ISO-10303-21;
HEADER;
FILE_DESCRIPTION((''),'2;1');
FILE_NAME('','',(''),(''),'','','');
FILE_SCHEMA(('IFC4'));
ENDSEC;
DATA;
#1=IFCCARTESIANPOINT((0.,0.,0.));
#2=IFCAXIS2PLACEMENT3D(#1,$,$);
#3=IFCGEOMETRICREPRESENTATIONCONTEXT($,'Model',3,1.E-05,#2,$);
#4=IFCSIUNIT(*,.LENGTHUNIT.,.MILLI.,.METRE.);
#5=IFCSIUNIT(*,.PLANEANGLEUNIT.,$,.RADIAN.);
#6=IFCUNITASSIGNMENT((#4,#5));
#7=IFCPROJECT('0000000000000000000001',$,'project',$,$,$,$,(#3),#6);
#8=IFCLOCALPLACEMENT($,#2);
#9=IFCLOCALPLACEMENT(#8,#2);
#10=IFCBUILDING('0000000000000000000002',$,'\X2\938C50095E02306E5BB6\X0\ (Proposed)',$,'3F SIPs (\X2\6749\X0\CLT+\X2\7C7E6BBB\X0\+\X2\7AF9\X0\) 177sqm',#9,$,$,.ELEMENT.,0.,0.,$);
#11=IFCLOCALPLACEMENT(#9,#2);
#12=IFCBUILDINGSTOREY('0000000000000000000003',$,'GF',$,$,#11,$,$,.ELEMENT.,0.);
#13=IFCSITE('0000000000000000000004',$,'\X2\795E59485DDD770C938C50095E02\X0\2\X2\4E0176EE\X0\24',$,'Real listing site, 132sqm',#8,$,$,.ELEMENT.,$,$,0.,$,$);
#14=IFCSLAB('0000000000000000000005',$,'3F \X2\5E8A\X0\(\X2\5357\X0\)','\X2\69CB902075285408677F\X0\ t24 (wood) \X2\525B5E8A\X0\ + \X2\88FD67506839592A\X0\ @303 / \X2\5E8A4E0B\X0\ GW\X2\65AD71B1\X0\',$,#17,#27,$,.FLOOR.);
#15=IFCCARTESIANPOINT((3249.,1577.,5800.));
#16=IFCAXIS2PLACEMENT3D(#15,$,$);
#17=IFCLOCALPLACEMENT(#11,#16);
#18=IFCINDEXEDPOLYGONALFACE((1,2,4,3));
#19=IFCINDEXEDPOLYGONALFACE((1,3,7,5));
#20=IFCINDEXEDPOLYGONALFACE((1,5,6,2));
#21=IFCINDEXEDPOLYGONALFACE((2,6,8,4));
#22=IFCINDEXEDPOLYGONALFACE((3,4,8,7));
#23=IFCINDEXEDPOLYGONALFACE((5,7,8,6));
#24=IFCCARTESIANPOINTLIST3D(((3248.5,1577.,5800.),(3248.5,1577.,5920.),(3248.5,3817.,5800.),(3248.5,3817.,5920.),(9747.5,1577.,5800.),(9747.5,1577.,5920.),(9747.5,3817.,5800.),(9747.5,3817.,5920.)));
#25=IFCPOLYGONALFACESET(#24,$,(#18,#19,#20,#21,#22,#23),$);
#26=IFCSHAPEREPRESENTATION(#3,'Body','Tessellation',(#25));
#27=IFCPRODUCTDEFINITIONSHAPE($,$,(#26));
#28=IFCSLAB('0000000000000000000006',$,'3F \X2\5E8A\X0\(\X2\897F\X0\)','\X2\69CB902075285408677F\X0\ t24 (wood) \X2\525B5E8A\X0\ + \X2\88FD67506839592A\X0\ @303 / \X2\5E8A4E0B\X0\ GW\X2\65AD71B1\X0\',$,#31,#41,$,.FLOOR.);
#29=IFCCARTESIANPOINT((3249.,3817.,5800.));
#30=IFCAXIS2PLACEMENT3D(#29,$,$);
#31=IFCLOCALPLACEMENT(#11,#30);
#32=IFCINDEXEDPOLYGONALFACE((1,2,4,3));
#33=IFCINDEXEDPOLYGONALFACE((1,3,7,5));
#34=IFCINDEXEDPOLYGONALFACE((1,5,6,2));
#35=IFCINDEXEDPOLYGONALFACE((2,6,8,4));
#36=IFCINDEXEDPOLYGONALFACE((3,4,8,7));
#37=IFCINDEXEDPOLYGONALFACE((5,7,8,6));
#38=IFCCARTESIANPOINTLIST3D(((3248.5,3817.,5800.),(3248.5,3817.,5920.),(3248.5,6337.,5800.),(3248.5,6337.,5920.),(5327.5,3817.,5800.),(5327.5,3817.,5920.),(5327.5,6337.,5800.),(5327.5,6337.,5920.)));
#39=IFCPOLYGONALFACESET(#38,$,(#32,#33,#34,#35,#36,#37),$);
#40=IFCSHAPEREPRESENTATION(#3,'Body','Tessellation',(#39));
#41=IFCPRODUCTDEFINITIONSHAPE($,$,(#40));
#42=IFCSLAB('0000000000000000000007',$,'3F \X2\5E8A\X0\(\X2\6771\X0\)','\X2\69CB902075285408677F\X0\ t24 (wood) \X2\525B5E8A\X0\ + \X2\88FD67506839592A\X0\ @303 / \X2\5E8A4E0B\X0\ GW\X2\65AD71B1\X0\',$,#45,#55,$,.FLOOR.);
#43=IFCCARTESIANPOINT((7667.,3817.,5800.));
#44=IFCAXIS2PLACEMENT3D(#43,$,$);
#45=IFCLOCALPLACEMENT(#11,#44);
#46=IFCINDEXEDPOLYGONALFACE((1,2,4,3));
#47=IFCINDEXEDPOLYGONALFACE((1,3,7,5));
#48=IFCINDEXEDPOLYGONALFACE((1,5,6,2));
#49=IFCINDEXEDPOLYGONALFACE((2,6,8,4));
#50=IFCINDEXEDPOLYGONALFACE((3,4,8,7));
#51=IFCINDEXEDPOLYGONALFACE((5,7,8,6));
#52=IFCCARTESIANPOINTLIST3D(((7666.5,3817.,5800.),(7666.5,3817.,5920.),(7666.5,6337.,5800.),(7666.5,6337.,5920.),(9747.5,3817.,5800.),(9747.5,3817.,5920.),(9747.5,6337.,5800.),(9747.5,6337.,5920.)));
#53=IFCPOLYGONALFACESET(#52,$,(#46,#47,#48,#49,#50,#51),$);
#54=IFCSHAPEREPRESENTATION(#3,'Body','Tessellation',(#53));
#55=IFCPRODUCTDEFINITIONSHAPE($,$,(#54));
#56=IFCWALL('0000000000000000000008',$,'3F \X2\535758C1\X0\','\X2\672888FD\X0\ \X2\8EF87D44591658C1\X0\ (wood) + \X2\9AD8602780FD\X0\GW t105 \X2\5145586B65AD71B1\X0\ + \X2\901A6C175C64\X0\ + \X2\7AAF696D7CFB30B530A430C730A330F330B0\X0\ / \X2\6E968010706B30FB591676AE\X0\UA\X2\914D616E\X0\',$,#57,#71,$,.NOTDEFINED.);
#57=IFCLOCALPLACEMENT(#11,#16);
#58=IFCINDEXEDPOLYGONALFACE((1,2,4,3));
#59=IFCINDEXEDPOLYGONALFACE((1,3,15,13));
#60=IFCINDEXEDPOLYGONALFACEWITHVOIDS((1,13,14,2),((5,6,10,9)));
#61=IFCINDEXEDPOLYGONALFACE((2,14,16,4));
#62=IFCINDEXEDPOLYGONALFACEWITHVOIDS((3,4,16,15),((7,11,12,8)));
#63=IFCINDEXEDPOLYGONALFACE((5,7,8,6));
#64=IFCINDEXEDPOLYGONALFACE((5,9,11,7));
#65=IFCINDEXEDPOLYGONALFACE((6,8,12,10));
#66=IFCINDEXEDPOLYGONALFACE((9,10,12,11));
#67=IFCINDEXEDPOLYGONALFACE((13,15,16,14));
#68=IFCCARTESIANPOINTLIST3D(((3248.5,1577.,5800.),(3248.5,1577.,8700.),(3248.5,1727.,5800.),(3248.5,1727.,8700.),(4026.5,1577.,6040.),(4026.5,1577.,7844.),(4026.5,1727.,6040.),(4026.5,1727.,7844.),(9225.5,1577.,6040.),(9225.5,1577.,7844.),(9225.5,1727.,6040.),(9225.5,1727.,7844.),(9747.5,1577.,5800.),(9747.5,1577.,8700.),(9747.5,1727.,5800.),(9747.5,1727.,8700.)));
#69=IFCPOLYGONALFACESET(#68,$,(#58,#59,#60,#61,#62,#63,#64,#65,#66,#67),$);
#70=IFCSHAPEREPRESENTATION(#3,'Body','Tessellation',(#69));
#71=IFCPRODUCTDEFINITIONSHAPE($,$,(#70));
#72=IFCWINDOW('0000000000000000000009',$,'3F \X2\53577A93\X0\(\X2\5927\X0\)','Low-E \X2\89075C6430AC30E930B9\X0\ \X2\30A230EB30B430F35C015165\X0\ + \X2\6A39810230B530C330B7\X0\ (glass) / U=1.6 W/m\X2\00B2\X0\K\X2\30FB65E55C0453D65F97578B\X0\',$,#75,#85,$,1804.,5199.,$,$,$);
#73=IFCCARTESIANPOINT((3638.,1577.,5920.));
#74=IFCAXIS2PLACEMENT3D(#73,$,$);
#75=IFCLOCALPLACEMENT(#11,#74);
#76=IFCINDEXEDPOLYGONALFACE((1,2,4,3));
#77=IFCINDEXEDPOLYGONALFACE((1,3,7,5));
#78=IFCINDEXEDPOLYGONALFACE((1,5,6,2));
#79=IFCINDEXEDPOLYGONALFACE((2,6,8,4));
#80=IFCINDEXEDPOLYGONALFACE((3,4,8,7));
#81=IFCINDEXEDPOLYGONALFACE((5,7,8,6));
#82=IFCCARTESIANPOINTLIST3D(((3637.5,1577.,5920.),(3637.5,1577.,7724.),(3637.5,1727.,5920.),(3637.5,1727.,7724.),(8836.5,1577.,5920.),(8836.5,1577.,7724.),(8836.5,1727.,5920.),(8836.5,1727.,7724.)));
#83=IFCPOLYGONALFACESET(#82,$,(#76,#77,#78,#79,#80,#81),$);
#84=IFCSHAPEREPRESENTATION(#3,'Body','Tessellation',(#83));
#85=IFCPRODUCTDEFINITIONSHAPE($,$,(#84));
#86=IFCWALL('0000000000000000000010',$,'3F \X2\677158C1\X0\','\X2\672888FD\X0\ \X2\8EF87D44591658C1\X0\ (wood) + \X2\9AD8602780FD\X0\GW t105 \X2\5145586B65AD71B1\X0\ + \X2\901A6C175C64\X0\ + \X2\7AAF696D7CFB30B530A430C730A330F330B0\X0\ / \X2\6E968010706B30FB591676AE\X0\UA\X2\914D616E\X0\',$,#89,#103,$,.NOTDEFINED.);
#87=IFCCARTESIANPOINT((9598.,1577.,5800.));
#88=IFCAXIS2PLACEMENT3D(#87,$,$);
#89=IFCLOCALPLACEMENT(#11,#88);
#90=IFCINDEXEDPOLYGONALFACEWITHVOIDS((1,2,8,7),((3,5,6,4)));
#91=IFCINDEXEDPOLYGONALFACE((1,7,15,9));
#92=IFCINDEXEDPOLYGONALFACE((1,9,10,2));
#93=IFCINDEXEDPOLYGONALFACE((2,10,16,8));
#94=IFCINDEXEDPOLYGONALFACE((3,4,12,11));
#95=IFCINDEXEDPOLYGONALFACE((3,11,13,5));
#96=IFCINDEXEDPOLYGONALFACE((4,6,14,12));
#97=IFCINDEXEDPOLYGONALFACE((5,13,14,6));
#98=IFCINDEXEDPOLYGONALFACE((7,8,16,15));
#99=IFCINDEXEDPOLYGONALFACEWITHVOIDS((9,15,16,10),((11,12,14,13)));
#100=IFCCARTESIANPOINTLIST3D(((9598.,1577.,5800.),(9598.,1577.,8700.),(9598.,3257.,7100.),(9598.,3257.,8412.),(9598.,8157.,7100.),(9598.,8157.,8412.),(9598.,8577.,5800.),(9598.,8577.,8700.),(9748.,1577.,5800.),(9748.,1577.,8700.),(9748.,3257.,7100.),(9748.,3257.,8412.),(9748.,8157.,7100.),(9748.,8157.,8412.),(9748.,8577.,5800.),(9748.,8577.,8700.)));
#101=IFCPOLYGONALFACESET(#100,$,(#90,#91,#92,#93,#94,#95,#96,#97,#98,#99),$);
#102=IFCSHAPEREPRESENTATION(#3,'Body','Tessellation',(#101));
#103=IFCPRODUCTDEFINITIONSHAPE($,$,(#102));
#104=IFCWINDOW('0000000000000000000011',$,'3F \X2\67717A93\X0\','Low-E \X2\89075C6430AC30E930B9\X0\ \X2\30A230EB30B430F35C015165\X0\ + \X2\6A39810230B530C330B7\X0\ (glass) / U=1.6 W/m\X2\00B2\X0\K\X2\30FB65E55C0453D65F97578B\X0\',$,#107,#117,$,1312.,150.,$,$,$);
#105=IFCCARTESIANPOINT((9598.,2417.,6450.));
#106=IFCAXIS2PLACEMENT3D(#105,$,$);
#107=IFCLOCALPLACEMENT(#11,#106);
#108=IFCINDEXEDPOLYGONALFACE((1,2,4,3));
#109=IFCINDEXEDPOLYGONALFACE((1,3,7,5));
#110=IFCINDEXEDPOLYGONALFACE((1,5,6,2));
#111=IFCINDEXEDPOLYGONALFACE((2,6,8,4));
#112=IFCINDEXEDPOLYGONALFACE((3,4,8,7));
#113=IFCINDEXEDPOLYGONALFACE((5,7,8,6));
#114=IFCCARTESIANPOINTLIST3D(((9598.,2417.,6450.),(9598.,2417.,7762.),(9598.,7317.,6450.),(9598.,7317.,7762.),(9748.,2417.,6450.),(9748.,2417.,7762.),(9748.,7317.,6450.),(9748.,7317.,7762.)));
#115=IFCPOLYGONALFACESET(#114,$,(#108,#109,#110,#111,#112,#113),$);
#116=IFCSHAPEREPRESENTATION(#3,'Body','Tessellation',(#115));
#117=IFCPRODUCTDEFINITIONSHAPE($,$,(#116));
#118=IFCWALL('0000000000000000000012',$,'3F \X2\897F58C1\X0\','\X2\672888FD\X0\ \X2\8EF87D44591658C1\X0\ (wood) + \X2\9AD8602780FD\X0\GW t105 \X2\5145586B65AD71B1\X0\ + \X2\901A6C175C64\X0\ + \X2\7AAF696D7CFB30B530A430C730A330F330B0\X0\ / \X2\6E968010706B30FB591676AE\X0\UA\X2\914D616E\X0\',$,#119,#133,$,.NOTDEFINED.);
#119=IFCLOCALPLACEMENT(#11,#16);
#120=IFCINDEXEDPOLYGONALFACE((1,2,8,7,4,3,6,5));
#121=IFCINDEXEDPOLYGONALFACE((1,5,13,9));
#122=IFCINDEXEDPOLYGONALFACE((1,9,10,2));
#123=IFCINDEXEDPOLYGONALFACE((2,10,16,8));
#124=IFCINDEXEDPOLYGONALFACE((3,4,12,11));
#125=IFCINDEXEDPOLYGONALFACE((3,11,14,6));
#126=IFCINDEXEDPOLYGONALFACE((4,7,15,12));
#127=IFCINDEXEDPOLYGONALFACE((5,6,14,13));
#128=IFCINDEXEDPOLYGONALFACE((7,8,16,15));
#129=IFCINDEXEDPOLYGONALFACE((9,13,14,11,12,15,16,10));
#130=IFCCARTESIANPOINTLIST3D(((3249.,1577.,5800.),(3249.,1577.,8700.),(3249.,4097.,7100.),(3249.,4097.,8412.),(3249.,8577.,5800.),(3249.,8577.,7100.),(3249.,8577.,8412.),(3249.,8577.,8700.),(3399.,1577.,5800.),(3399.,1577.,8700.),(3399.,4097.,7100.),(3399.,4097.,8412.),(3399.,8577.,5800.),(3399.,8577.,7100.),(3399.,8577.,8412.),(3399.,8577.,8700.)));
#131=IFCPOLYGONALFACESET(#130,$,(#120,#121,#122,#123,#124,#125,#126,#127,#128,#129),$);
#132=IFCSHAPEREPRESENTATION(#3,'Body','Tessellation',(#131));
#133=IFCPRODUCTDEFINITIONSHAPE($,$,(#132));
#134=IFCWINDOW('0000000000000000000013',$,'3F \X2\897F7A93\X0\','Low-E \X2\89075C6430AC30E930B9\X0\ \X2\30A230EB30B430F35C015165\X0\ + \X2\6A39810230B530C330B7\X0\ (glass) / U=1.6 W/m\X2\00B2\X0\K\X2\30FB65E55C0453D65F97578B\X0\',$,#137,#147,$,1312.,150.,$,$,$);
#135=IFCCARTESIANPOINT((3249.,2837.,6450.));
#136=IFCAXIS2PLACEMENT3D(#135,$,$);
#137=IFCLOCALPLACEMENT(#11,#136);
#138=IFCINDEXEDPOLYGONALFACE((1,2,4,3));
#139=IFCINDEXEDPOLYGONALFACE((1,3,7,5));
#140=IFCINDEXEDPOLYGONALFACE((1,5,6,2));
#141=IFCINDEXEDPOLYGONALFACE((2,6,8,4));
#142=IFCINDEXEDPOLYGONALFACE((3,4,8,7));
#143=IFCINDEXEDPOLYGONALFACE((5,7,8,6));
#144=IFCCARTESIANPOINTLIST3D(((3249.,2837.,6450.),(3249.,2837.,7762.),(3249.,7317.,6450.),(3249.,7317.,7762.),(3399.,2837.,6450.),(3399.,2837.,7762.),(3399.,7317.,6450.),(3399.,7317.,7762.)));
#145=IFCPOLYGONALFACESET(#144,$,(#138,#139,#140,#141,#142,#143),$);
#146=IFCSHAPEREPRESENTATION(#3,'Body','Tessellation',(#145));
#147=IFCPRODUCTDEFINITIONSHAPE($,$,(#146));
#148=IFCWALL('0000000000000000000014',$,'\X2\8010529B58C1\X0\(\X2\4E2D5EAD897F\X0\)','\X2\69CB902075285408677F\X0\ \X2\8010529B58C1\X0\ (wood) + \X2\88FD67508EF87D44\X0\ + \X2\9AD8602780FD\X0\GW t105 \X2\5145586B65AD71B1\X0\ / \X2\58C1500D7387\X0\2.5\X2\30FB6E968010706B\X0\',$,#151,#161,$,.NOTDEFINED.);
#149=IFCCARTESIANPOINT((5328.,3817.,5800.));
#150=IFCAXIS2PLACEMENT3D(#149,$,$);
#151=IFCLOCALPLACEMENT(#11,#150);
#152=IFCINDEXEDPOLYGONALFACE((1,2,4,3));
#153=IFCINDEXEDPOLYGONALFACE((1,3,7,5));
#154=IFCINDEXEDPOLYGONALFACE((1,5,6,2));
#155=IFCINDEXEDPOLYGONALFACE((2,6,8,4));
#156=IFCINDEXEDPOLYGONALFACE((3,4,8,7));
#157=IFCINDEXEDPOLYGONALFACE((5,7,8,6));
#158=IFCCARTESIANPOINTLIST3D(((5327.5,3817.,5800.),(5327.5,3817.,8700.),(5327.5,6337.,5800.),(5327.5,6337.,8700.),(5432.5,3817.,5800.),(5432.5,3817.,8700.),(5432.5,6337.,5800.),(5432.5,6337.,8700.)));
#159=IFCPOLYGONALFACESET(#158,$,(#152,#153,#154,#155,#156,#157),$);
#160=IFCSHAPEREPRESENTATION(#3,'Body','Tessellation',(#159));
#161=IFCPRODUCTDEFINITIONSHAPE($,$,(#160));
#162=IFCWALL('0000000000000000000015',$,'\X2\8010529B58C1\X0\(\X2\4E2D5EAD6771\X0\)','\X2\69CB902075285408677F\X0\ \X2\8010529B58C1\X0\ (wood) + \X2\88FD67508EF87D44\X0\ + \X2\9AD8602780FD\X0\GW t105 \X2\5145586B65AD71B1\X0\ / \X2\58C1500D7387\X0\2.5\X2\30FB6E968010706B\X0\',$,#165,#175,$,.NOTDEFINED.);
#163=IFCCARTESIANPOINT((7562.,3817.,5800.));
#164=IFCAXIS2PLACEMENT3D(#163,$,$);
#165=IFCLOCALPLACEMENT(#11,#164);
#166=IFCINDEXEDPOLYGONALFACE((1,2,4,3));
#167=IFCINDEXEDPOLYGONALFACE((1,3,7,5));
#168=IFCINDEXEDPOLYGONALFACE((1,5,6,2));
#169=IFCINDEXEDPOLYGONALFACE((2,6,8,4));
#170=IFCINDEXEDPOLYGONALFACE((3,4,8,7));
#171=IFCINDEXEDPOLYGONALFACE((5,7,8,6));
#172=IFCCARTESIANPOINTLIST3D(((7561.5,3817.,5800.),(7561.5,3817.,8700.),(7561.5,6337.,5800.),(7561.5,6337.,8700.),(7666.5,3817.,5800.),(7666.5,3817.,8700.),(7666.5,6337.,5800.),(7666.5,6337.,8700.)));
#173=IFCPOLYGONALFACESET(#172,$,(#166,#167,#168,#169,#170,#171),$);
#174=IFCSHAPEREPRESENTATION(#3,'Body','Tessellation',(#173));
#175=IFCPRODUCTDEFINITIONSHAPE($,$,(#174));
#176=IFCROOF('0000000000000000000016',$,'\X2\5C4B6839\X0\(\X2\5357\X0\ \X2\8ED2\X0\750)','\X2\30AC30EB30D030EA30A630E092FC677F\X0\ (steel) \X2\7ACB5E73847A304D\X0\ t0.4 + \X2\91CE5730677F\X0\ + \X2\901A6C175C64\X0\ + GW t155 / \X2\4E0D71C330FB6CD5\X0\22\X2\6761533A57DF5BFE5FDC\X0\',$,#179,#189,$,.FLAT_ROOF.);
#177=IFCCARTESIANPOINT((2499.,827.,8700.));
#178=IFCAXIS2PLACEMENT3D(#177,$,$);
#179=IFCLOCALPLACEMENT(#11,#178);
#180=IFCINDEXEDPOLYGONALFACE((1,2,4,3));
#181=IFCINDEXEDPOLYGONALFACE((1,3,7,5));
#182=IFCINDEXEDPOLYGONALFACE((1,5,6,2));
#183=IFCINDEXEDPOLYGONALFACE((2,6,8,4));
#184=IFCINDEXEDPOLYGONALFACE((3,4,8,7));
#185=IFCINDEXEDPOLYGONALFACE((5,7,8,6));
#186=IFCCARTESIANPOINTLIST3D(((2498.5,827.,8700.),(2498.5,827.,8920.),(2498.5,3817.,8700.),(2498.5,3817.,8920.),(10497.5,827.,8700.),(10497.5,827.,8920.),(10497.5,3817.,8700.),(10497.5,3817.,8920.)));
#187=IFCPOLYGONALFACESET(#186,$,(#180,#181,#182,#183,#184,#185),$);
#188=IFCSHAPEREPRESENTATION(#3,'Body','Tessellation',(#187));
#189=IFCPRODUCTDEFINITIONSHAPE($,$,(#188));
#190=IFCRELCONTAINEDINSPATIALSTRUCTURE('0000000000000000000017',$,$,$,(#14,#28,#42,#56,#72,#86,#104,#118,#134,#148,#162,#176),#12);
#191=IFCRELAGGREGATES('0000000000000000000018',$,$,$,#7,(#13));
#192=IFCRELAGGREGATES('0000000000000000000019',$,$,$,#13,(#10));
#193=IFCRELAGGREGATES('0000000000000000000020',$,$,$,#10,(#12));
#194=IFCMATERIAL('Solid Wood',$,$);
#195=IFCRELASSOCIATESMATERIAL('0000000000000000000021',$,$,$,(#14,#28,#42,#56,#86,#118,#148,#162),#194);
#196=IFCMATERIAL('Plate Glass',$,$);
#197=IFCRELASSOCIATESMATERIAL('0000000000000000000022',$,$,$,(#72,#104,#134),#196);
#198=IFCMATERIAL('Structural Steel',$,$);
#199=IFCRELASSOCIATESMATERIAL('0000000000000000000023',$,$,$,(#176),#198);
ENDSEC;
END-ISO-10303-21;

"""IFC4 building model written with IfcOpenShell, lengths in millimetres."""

from ifc_helpers import new_model, si_unit, frame, frame_2d, origin, place, context, project, spatial, rectangle, extrude, material, element, fill, save


model = new_model("IFC4")

# Units and contexts
model_context = context("Model", 3, precision=1e-05, world=origin())
ifc_project = project(units=[si_unit("LENGTHUNIT", "METRE", prefix="MILLI"), si_unit("PLANEANGLEUNIT", "RADIAN")], contexts=[model_context])

# Site, building, storey
site_placement = place(None, origin())
site = spatial("IfcSite", under=ifc_project, at=site_placement, Name="神奈川県鎌倉市2丁目24", ObjectType="Real listing site, 132sqm", CompositionType="ELEMENT", RefElevation=0.0)
building_placement = place(site_placement, origin())
building = spatial("IfcBuilding", under=site, at=building_placement, Name="鎌倉市の家 (Proposed)", ObjectType="3F SIPs (杉CLT+籾殻+竹) 177sqm", CompositionType="ELEMENT", ElevationOfRefHeight=0.0, ElevationOfTerrain=0.0)
storey_placement = place(building_placement, origin())
storey = spatial("IfcBuildingStorey", under=building, at=storey_placement, Name="GF", CompositionType="ELEMENT", Elevation=0.0)

# Slabs
ifc_material_1 = material(Name="Solid Wood")
slab_1_placement = place(storey_placement, frame((3249.0, 1577.0, 5800.0)))
element("IfcSlab", 1, at=slab_1_placement, inside=storey, material=ifc_material_1, Name="3F 床(南)", Description="構造用合板 t24 (wood) 剛床 + 製材根太 @303 / 床下 GW断熱", PredefinedType="FLOOR", context=model_context, shape_type="SweptSolid", body=[
    extrude(rectangle(XDim=6499.0, YDim=2240.0, at=frame_2d((3249.0, 1120.0))), frame((3249.0, 1577.0, 5800.0)), (0.0, 0.0, 1.0), 120.0),
])
slab_2_placement = place(storey_placement, frame((3249.0, 3817.0, 5800.0)))
element("IfcSlab", 2, at=slab_2_placement, inside=storey, material=ifc_material_1, Name="3F 床(西)", Description="構造用合板 t24 (wood) 剛床 + 製材根太 @303 / 床下 GW断熱", PredefinedType="FLOOR", context=model_context, shape_type="SweptSolid", body=[
    extrude(rectangle(XDim=2079.0, YDim=2520.0, at=frame_2d((1039.0, 1260.0))), frame((3249.0, 3817.0, 5800.0)), (0.0, 0.0, 1.0), 120.0),
])
slab_3_placement = place(storey_placement, frame((7667.0, 3817.0, 5800.0)))
element("IfcSlab", 3, at=slab_3_placement, inside=storey, material=ifc_material_1, Name="3F 床(東)", Description="構造用合板 t24 (wood) 剛床 + 製材根太 @303 / 床下 GW断熱", PredefinedType="FLOOR", context=model_context, shape_type="SweptSolid", body=[
    extrude(rectangle(XDim=2081.0, YDim=2520.0, at=frame_2d((1040.0, 1260.0))), frame((7667.0, 3817.0, 5800.0)), (0.0, 0.0, 1.0), 120.0),
])

# Walls, openings, windows
wall_1_placement = place(storey_placement, frame((3249.0, 1577.0, 5800.0)))
wall_1 = element("IfcWall", 4, at=wall_1_placement, inside=storey, material=ifc_material_1, Name="3F 南壁", Description="木製 軸組外壁 (wood) + 高性能GW t105 充填断熱 + 通気層 + 窯業系サイディング / 準耐火・外皮UA配慮", PredefinedType="NOTDEFINED", context=model_context, shape_type="SweptSolid", body=[
    extrude(rectangle(XDim=6499.0, YDim=150.0, at=frame_2d((3249.0, 75.0))), frame((3249.0, 1577.0, 5800.0)), (0.0, 0.0, 1.0), 2900.0),
])
opening_1_placement = place(storey_placement, frame((3638.0, 1577.0, 5920.0)))
opening_1 = element("IfcOpeningElement", 5, at=opening_1_placement, cuts=wall_1, PredefinedType="NOTDEFINED", context=model_context, shape_type="SweptSolid", body=[
    extrude(rectangle(XDim=5199.0, YDim=150.0, at=frame_2d((2599.0, 75.0))), frame((3638.0, 1577.0, 5920.0)), (0.0, 0.0, 1.0), 1804.0),
])
ifc_material_2 = material(Name="Plate Glass")
window_1_placement = place(storey_placement, frame((3638.0, 1577.0, 5920.0)))
window_1 = element("IfcWindow", 6, at=window_1_placement, inside=storey, material=ifc_material_2, Name="3F 南窓(大)", Description="Low-E 複層ガラス アルゴン封入 + 樹脂サッシ (glass) / U=1.6 W/m²K・日射取得型", OverallHeight=1804.0, OverallWidth=5199.0, context=model_context, shape_type="SweptSolid", body=[
    extrude(rectangle(XDim=5199.0, YDim=150.0, at=frame_2d((2599.0, 75.0))), frame((3638.0, 1577.0, 5920.0)), (0.0, 0.0, 1.0), 1804.0),
])
fill(opening_1, window_1)
wall_2_placement = place(storey_placement, frame((9598.0, 1577.0, 5800.0)))
wall_2 = element("IfcWall", 7, at=wall_2_placement, inside=storey, material=ifc_material_1, Name="3F 東壁", Description="木製 軸組外壁 (wood) + 高性能GW t105 充填断熱 + 通気層 + 窯業系サイディング / 準耐火・外皮UA配慮", PredefinedType="NOTDEFINED", context=model_context, shape_type="SweptSolid", body=[
    extrude(rectangle(XDim=150.0, YDim=7000.0, at=frame_2d((75.0, 3500.0))), frame((9598.0, 1577.0, 5800.0)), (0.0, 0.0, 1.0), 2900.0),
])
opening_2_placement = place(storey_placement, frame((9598.0, 2417.0, 6450.0)))
opening_2 = element("IfcOpeningElement", 8, at=opening_2_placement, cuts=wall_2, PredefinedType="NOTDEFINED", context=model_context, shape_type="SweptSolid", body=[
    extrude(rectangle(XDim=150.0, YDim=4900.0, at=frame_2d((75.0, 2450.0))), frame((9598.0, 2417.0, 6450.0)), (0.0, 0.0, 1.0), 1312.0),
])
window_2_placement = place(storey_placement, frame((9598.0, 2417.0, 6450.0)))
window_2 = element("IfcWindow", 9, at=window_2_placement, inside=storey, material=ifc_material_2, Name="3F 東窓", Description="Low-E 複層ガラス アルゴン封入 + 樹脂サッシ (glass) / U=1.6 W/m²K・日射取得型", OverallHeight=1312.0, OverallWidth=150.0, context=model_context, shape_type="SweptSolid", body=[
    extrude(rectangle(XDim=150.0, YDim=4900.0, at=frame_2d((75.0, 2450.0))), frame((9598.0, 2417.0, 6450.0)), (0.0, 0.0, 1.0), 1312.0),
])
fill(opening_2, window_2)
wall_3_placement = place(storey_placement, frame((3249.0, 1577.0, 5800.0)))
wall_3 = element("IfcWall", 10, at=wall_3_placement, inside=storey, material=ifc_material_1, Name="3F 西壁", Description="木製 軸組外壁 (wood) + 高性能GW t105 充填断熱 + 通気層 + 窯業系サイディング / 準耐火・外皮UA配慮", PredefinedType="NOTDEFINED", context=model_context, shape_type="SweptSolid", body=[
    extrude(rectangle(XDim=150.0, YDim=7000.0, at=frame_2d((75.0, 3500.0))), frame((3249.0, 1577.0, 5800.0)), (0.0, 0.0, 1.0), 2900.0),
])
opening_3_placement = place(storey_placement, frame((3249.0, 2837.0, 6450.0)))
opening_3 = element("IfcOpeningElement", 11, at=opening_3_placement, cuts=wall_3, PredefinedType="NOTDEFINED", context=model_context, shape_type="SweptSolid", body=[
    extrude(rectangle(XDim=150.0, YDim=4480.0, at=frame_2d((75.0, 2240.0))), frame((3249.0, 2837.0, 6450.0)), (0.0, 0.0, 1.0), 1312.0),
])
window_3_placement = place(storey_placement, frame((3249.0, 2837.0, 6450.0)))
window_3 = element("IfcWindow", 12, at=window_3_placement, inside=storey, material=ifc_material_2, Name="3F 西窓", Description="Low-E 複層ガラス アルゴン封入 + 樹脂サッシ (glass) / U=1.6 W/m²K・日射取得型", OverallHeight=1312.0, OverallWidth=150.0, context=model_context, shape_type="SweptSolid", body=[
    extrude(rectangle(XDim=150.0, YDim=4480.0, at=frame_2d((75.0, 2240.0))), frame((3249.0, 2837.0, 6450.0)), (0.0, 0.0, 1.0), 1312.0),
])
fill(opening_3, window_3)

# Walls
wall_4_placement = place(storey_placement, frame((5328.0, 3817.0, 5800.0)))
element("IfcWall", 13, at=wall_4_placement, inside=storey, material=ifc_material_1, Name="耐力壁(中庭西)", Description="構造用合板 耐力壁 (wood) + 製材軸組 + 高性能GW t105 充填断熱 / 壁倍率2.5・準耐火", PredefinedType="NOTDEFINED", context=model_context, shape_type="SweptSolid", body=[
    extrude(rectangle(XDim=105.0, YDim=2520.0, at=frame_2d((52.0, 1260.0))), frame((5328.0, 3817.0, 5800.0)), (0.0, 0.0, 1.0), 2900.0),
])
wall_5_placement = place(storey_placement, frame((7562.0, 3817.0, 5800.0)))
element("IfcWall", 14, at=wall_5_placement, inside=storey, material=ifc_material_1, Name="耐力壁(中庭東)", Description="構造用合板 耐力壁 (wood) + 製材軸組 + 高性能GW t105 充填断熱 / 壁倍率2.5・準耐火", PredefinedType="NOTDEFINED", context=model_context, shape_type="SweptSolid", body=[
    extrude(rectangle(XDim=105.0, YDim=2520.0, at=frame_2d((52.0, 1260.0))), frame((7562.0, 3817.0, 5800.0)), (0.0, 0.0, 1.0), 2900.0),
])

# Roof
ifc_material_3 = material(Name="Structural Steel")
roof_1_placement = place(storey_placement, frame((2499.0, 827.0, 8700.0)))
element("IfcRoof", 15, at=roof_1_placement, inside=storey, material=ifc_material_3, Name="屋根(南 軒750)", Description="ガルバリウム鋼板 (steel) 立平葺き t0.4 + 野地板 + 通気層 + GW t155 / 不燃・法22条区域対応", PredefinedType="FLAT_ROOF", context=model_context, shape_type="SweptSolid", body=[
    extrude(rectangle(XDim=7999.0, YDim=2990.0, at=frame_2d((3999.0, 1495.0))), frame((2499.0, 827.0, 8700.0)), (0.0, 0.0, 1.0), 220.0),
])

save(model, "model.ifc")
